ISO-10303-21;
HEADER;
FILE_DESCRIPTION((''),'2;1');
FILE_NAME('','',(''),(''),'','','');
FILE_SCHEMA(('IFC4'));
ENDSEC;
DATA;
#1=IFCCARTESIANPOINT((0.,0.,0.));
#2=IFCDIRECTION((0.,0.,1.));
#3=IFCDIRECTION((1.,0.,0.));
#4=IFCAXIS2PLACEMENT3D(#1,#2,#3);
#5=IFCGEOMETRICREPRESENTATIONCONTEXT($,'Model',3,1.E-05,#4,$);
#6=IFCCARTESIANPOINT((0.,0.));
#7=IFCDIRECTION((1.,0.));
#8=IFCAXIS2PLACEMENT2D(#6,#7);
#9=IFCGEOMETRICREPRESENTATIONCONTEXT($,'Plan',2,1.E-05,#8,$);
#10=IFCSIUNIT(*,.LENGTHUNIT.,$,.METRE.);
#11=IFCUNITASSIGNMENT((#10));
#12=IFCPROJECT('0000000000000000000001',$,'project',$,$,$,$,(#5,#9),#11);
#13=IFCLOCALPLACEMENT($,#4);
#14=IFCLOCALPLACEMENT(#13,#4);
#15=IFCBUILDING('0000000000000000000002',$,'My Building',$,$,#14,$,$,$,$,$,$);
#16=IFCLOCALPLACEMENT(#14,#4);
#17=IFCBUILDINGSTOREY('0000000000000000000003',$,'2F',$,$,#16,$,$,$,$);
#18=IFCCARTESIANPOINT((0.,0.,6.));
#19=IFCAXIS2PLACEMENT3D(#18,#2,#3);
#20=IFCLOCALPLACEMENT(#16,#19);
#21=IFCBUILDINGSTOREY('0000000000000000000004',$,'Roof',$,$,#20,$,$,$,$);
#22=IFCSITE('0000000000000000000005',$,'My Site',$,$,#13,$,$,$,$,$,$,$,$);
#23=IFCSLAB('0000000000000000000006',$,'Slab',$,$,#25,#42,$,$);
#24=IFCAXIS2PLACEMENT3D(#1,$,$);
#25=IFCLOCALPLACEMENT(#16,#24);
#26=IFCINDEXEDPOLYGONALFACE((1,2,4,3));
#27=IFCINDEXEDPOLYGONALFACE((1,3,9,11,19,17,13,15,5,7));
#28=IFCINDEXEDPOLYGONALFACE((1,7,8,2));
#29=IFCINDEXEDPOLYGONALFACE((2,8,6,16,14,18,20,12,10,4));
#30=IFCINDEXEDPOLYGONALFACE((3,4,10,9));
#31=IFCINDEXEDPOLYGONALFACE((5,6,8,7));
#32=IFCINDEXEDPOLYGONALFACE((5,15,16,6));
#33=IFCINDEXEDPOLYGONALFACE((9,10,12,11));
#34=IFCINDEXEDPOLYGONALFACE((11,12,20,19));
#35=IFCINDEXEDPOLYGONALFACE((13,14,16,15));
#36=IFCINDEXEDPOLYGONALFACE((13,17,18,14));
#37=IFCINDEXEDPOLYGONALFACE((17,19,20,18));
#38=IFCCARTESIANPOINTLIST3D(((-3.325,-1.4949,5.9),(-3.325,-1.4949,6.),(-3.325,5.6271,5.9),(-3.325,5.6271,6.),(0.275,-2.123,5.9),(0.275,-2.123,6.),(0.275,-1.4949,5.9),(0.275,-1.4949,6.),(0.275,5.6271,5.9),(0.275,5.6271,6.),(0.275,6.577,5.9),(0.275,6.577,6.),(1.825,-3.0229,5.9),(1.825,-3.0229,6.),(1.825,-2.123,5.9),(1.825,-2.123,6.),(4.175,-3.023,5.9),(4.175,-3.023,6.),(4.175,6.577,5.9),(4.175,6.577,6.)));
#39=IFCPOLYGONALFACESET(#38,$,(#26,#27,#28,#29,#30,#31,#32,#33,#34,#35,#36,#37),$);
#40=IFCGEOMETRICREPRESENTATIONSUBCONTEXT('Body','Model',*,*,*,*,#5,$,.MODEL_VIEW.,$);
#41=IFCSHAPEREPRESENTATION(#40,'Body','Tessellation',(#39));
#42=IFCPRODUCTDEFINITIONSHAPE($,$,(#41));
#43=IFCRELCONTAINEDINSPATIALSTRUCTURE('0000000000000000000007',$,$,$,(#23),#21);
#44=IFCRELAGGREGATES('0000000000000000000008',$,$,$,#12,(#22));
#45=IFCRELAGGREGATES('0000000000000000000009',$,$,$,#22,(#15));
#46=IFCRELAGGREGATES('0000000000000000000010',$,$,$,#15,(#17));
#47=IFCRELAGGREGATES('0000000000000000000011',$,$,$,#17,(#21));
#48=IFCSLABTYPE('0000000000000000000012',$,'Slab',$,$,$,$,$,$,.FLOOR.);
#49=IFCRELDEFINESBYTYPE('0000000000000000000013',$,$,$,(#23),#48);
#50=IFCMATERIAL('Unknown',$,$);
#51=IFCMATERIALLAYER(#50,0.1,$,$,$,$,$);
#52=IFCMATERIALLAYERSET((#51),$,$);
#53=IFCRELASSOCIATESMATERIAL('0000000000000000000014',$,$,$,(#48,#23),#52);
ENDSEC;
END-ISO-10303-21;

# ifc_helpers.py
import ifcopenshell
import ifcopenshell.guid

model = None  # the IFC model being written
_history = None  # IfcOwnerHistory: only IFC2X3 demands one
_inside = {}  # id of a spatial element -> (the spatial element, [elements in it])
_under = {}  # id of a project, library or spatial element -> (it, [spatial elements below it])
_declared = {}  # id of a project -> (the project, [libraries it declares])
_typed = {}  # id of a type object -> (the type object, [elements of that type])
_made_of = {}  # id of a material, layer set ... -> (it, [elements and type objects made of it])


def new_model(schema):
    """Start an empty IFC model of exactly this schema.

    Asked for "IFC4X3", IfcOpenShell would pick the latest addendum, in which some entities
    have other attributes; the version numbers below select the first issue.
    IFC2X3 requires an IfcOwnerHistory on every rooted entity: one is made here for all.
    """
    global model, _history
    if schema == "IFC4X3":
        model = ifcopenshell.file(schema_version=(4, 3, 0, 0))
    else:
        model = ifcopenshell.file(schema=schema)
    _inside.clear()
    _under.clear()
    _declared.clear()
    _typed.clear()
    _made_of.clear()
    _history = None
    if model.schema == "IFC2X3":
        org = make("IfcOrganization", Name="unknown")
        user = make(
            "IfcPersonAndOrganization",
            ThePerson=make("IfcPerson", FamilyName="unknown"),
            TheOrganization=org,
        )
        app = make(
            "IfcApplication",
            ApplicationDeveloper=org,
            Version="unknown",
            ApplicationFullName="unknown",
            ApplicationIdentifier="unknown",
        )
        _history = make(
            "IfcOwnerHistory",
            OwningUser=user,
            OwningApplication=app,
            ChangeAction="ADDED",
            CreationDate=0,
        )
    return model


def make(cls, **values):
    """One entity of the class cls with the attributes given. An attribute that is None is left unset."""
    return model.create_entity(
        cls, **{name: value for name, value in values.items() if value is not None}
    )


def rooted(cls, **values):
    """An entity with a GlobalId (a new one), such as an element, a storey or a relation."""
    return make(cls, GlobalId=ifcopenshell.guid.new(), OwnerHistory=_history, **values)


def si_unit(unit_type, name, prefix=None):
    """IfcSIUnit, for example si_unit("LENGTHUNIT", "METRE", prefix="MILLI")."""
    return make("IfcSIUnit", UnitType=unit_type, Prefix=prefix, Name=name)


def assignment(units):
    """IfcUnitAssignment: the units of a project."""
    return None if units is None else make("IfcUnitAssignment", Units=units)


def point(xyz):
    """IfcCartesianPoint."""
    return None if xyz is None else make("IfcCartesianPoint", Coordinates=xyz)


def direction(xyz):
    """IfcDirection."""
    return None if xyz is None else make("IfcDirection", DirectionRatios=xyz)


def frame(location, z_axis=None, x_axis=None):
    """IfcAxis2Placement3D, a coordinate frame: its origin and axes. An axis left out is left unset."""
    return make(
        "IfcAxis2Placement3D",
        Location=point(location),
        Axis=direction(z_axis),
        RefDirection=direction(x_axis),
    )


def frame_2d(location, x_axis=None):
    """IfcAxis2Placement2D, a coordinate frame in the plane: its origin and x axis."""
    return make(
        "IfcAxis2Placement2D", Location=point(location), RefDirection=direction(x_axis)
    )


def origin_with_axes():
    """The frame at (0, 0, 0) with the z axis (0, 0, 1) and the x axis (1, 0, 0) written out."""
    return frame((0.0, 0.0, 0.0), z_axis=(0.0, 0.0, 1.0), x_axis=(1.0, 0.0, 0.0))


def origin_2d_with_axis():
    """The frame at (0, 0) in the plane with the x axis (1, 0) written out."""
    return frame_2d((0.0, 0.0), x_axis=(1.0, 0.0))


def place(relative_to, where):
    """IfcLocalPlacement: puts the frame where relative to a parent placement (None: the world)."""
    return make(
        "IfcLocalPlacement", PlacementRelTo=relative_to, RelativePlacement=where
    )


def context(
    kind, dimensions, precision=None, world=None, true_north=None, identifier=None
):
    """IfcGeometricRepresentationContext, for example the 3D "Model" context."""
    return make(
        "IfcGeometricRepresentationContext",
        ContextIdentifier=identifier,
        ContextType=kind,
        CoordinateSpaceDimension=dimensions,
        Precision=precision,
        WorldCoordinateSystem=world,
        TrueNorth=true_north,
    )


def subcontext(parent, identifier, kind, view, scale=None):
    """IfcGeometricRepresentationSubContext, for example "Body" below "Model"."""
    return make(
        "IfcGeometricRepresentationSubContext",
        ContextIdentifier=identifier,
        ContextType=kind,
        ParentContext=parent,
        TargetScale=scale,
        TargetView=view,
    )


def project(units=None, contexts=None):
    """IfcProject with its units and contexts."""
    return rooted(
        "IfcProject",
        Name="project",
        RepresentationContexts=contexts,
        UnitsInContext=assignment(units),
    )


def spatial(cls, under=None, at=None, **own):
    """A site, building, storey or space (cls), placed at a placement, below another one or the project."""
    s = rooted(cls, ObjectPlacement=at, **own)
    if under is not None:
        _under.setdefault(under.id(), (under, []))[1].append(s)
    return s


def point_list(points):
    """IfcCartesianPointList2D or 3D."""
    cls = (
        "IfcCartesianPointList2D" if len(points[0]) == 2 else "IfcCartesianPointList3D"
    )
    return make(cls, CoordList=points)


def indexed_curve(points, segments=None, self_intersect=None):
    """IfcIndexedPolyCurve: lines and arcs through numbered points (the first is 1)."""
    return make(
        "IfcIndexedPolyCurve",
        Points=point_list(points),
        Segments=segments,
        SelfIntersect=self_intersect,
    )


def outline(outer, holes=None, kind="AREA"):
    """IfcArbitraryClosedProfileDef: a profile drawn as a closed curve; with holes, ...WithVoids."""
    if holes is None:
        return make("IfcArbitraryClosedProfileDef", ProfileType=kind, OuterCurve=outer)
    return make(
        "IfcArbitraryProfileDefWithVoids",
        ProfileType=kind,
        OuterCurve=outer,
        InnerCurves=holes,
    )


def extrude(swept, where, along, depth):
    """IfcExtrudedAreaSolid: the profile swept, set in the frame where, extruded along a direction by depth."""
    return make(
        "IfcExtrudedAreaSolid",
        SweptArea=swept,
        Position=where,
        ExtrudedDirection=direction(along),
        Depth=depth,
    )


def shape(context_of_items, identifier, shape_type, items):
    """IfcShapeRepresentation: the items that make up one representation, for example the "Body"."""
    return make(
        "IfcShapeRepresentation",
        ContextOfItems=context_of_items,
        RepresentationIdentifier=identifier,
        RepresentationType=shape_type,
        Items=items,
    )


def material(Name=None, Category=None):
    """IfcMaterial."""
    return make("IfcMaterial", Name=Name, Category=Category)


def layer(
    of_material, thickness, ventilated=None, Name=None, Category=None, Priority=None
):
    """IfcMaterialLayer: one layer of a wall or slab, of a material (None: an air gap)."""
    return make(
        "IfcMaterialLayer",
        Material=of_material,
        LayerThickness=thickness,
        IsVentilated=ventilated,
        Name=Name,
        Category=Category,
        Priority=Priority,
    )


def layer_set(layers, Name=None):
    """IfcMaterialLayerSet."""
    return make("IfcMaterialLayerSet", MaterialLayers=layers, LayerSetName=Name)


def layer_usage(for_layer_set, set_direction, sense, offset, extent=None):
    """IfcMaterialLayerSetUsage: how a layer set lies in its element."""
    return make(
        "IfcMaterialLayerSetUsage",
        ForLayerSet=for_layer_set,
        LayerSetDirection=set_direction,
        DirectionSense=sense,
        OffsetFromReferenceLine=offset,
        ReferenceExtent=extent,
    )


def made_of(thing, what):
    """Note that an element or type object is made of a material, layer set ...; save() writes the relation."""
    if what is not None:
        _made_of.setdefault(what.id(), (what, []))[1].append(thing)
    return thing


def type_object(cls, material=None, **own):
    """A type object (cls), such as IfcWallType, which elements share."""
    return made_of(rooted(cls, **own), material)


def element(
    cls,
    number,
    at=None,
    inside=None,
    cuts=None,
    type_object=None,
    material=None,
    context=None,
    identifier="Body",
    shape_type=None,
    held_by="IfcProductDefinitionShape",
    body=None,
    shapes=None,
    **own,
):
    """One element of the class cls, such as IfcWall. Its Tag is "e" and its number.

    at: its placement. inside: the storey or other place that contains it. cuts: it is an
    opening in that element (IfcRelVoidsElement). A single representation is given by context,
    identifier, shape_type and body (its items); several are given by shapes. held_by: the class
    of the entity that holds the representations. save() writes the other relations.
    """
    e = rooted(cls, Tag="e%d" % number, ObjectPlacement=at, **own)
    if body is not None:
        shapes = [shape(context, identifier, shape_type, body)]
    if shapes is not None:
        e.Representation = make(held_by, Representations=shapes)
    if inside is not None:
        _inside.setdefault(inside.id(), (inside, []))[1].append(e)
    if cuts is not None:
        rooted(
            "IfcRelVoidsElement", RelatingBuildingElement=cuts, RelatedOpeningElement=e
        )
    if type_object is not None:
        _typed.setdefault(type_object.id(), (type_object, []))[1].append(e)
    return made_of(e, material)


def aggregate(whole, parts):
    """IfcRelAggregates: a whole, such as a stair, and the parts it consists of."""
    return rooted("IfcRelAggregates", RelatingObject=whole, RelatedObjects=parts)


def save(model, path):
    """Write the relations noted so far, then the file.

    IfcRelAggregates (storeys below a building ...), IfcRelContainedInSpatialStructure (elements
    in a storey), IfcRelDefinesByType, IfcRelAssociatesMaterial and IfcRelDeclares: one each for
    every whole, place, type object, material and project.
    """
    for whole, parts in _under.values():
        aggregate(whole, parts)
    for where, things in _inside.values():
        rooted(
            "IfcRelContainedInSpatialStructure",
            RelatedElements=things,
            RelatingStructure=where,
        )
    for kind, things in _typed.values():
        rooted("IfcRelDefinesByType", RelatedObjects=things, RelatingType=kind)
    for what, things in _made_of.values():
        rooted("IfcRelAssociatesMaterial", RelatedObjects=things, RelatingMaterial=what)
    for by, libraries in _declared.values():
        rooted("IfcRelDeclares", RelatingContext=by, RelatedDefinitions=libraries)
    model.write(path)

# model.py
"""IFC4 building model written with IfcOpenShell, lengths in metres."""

from ifc_helpers import new_model, si_unit, frame, origin_with_axes, origin_2d_with_axis, place, context, subcontext, project, spatial, indexed_curve, outline, extrude, material, layer, layer_set, layer_usage, type_object, element, save


model = new_model("IFC4")

# Units and contexts
model_context = context("Model", 3, precision=1e-05, world=origin_with_axes())
plan_context = context("Plan", 2, precision=1e-05, world=origin_2d_with_axis())
body_context = subcontext(model_context, "Body", "Model", "MODEL_VIEW")
ifc_project = project(units=[si_unit("LENGTHUNIT", "METRE")], contexts=[model_context, plan_context])

# Site, building, storeys
site_placement = place(None, origin_with_axes())
site = spatial("IfcSite", under=ifc_project, at=site_placement, Name="My Site")
building_placement = place(site_placement, origin_with_axes())
building = spatial("IfcBuilding", under=site, at=building_placement, Name="My Building")
storey_1_placement = place(building_placement, origin_with_axes())
storey_1 = spatial("IfcBuildingStorey", under=building, at=storey_1_placement, Name="2F")
storey_2_placement = place(storey_1_placement, frame((0.0, 0.0, 6.0), z_axis=(0.0, 0.0, 1.0), x_axis=(1.0, 0.0, 0.0)))
storey_2 = spatial("IfcBuildingStorey", under=storey_1, at=storey_2_placement, Name="Roof")

# Slab
ifc_material = material(Name="Unknown")
ifc_layer = layer(ifc_material, 0.1)
ifc_layer_set = layer_set([ifc_layer])
ifc_layer_usage = layer_usage(ifc_layer_set, "AXIS3", "POSITIVE", -0.1)
slab_type = type_object("IfcSlabType", Name="Slab", PredefinedType="FLOOR", material=ifc_layer_set)
slab_placement = place(storey_2_placement, frame((4.175, -3.023, 0.0), z_axis=(0.0, 0.0, 1.0), x_axis=(1.0, 0.0, 0.0)))
element("IfcSlab", 1, at=slab_placement, inside=storey_2, type_object=slab_type, material=ifc_layer_usage, Name="Slab", context=body_context, shape_type="SweptSolid", body=[
    extrude(outline(indexed_curve([(0.0, 0.0), (0.0, 9.6), (-3.9, 9.6), (-3.9, 8.65), (-7.5, 8.65), (-7.5, 1.5281), (-3.9, 1.5281), (-3.9, 0.9), (-2.35, 0.9), (-2.35, 0.0001), (0.0, 0.0)])), frame((0.0, 0.0, -0.1), z_axis=(0.0, 0.0, 1.0), x_axis=(1.0, 0.0, 0.0)), (0.0, 0.0, 1.0), 0.1),
])

save(model, "model.ifc")
